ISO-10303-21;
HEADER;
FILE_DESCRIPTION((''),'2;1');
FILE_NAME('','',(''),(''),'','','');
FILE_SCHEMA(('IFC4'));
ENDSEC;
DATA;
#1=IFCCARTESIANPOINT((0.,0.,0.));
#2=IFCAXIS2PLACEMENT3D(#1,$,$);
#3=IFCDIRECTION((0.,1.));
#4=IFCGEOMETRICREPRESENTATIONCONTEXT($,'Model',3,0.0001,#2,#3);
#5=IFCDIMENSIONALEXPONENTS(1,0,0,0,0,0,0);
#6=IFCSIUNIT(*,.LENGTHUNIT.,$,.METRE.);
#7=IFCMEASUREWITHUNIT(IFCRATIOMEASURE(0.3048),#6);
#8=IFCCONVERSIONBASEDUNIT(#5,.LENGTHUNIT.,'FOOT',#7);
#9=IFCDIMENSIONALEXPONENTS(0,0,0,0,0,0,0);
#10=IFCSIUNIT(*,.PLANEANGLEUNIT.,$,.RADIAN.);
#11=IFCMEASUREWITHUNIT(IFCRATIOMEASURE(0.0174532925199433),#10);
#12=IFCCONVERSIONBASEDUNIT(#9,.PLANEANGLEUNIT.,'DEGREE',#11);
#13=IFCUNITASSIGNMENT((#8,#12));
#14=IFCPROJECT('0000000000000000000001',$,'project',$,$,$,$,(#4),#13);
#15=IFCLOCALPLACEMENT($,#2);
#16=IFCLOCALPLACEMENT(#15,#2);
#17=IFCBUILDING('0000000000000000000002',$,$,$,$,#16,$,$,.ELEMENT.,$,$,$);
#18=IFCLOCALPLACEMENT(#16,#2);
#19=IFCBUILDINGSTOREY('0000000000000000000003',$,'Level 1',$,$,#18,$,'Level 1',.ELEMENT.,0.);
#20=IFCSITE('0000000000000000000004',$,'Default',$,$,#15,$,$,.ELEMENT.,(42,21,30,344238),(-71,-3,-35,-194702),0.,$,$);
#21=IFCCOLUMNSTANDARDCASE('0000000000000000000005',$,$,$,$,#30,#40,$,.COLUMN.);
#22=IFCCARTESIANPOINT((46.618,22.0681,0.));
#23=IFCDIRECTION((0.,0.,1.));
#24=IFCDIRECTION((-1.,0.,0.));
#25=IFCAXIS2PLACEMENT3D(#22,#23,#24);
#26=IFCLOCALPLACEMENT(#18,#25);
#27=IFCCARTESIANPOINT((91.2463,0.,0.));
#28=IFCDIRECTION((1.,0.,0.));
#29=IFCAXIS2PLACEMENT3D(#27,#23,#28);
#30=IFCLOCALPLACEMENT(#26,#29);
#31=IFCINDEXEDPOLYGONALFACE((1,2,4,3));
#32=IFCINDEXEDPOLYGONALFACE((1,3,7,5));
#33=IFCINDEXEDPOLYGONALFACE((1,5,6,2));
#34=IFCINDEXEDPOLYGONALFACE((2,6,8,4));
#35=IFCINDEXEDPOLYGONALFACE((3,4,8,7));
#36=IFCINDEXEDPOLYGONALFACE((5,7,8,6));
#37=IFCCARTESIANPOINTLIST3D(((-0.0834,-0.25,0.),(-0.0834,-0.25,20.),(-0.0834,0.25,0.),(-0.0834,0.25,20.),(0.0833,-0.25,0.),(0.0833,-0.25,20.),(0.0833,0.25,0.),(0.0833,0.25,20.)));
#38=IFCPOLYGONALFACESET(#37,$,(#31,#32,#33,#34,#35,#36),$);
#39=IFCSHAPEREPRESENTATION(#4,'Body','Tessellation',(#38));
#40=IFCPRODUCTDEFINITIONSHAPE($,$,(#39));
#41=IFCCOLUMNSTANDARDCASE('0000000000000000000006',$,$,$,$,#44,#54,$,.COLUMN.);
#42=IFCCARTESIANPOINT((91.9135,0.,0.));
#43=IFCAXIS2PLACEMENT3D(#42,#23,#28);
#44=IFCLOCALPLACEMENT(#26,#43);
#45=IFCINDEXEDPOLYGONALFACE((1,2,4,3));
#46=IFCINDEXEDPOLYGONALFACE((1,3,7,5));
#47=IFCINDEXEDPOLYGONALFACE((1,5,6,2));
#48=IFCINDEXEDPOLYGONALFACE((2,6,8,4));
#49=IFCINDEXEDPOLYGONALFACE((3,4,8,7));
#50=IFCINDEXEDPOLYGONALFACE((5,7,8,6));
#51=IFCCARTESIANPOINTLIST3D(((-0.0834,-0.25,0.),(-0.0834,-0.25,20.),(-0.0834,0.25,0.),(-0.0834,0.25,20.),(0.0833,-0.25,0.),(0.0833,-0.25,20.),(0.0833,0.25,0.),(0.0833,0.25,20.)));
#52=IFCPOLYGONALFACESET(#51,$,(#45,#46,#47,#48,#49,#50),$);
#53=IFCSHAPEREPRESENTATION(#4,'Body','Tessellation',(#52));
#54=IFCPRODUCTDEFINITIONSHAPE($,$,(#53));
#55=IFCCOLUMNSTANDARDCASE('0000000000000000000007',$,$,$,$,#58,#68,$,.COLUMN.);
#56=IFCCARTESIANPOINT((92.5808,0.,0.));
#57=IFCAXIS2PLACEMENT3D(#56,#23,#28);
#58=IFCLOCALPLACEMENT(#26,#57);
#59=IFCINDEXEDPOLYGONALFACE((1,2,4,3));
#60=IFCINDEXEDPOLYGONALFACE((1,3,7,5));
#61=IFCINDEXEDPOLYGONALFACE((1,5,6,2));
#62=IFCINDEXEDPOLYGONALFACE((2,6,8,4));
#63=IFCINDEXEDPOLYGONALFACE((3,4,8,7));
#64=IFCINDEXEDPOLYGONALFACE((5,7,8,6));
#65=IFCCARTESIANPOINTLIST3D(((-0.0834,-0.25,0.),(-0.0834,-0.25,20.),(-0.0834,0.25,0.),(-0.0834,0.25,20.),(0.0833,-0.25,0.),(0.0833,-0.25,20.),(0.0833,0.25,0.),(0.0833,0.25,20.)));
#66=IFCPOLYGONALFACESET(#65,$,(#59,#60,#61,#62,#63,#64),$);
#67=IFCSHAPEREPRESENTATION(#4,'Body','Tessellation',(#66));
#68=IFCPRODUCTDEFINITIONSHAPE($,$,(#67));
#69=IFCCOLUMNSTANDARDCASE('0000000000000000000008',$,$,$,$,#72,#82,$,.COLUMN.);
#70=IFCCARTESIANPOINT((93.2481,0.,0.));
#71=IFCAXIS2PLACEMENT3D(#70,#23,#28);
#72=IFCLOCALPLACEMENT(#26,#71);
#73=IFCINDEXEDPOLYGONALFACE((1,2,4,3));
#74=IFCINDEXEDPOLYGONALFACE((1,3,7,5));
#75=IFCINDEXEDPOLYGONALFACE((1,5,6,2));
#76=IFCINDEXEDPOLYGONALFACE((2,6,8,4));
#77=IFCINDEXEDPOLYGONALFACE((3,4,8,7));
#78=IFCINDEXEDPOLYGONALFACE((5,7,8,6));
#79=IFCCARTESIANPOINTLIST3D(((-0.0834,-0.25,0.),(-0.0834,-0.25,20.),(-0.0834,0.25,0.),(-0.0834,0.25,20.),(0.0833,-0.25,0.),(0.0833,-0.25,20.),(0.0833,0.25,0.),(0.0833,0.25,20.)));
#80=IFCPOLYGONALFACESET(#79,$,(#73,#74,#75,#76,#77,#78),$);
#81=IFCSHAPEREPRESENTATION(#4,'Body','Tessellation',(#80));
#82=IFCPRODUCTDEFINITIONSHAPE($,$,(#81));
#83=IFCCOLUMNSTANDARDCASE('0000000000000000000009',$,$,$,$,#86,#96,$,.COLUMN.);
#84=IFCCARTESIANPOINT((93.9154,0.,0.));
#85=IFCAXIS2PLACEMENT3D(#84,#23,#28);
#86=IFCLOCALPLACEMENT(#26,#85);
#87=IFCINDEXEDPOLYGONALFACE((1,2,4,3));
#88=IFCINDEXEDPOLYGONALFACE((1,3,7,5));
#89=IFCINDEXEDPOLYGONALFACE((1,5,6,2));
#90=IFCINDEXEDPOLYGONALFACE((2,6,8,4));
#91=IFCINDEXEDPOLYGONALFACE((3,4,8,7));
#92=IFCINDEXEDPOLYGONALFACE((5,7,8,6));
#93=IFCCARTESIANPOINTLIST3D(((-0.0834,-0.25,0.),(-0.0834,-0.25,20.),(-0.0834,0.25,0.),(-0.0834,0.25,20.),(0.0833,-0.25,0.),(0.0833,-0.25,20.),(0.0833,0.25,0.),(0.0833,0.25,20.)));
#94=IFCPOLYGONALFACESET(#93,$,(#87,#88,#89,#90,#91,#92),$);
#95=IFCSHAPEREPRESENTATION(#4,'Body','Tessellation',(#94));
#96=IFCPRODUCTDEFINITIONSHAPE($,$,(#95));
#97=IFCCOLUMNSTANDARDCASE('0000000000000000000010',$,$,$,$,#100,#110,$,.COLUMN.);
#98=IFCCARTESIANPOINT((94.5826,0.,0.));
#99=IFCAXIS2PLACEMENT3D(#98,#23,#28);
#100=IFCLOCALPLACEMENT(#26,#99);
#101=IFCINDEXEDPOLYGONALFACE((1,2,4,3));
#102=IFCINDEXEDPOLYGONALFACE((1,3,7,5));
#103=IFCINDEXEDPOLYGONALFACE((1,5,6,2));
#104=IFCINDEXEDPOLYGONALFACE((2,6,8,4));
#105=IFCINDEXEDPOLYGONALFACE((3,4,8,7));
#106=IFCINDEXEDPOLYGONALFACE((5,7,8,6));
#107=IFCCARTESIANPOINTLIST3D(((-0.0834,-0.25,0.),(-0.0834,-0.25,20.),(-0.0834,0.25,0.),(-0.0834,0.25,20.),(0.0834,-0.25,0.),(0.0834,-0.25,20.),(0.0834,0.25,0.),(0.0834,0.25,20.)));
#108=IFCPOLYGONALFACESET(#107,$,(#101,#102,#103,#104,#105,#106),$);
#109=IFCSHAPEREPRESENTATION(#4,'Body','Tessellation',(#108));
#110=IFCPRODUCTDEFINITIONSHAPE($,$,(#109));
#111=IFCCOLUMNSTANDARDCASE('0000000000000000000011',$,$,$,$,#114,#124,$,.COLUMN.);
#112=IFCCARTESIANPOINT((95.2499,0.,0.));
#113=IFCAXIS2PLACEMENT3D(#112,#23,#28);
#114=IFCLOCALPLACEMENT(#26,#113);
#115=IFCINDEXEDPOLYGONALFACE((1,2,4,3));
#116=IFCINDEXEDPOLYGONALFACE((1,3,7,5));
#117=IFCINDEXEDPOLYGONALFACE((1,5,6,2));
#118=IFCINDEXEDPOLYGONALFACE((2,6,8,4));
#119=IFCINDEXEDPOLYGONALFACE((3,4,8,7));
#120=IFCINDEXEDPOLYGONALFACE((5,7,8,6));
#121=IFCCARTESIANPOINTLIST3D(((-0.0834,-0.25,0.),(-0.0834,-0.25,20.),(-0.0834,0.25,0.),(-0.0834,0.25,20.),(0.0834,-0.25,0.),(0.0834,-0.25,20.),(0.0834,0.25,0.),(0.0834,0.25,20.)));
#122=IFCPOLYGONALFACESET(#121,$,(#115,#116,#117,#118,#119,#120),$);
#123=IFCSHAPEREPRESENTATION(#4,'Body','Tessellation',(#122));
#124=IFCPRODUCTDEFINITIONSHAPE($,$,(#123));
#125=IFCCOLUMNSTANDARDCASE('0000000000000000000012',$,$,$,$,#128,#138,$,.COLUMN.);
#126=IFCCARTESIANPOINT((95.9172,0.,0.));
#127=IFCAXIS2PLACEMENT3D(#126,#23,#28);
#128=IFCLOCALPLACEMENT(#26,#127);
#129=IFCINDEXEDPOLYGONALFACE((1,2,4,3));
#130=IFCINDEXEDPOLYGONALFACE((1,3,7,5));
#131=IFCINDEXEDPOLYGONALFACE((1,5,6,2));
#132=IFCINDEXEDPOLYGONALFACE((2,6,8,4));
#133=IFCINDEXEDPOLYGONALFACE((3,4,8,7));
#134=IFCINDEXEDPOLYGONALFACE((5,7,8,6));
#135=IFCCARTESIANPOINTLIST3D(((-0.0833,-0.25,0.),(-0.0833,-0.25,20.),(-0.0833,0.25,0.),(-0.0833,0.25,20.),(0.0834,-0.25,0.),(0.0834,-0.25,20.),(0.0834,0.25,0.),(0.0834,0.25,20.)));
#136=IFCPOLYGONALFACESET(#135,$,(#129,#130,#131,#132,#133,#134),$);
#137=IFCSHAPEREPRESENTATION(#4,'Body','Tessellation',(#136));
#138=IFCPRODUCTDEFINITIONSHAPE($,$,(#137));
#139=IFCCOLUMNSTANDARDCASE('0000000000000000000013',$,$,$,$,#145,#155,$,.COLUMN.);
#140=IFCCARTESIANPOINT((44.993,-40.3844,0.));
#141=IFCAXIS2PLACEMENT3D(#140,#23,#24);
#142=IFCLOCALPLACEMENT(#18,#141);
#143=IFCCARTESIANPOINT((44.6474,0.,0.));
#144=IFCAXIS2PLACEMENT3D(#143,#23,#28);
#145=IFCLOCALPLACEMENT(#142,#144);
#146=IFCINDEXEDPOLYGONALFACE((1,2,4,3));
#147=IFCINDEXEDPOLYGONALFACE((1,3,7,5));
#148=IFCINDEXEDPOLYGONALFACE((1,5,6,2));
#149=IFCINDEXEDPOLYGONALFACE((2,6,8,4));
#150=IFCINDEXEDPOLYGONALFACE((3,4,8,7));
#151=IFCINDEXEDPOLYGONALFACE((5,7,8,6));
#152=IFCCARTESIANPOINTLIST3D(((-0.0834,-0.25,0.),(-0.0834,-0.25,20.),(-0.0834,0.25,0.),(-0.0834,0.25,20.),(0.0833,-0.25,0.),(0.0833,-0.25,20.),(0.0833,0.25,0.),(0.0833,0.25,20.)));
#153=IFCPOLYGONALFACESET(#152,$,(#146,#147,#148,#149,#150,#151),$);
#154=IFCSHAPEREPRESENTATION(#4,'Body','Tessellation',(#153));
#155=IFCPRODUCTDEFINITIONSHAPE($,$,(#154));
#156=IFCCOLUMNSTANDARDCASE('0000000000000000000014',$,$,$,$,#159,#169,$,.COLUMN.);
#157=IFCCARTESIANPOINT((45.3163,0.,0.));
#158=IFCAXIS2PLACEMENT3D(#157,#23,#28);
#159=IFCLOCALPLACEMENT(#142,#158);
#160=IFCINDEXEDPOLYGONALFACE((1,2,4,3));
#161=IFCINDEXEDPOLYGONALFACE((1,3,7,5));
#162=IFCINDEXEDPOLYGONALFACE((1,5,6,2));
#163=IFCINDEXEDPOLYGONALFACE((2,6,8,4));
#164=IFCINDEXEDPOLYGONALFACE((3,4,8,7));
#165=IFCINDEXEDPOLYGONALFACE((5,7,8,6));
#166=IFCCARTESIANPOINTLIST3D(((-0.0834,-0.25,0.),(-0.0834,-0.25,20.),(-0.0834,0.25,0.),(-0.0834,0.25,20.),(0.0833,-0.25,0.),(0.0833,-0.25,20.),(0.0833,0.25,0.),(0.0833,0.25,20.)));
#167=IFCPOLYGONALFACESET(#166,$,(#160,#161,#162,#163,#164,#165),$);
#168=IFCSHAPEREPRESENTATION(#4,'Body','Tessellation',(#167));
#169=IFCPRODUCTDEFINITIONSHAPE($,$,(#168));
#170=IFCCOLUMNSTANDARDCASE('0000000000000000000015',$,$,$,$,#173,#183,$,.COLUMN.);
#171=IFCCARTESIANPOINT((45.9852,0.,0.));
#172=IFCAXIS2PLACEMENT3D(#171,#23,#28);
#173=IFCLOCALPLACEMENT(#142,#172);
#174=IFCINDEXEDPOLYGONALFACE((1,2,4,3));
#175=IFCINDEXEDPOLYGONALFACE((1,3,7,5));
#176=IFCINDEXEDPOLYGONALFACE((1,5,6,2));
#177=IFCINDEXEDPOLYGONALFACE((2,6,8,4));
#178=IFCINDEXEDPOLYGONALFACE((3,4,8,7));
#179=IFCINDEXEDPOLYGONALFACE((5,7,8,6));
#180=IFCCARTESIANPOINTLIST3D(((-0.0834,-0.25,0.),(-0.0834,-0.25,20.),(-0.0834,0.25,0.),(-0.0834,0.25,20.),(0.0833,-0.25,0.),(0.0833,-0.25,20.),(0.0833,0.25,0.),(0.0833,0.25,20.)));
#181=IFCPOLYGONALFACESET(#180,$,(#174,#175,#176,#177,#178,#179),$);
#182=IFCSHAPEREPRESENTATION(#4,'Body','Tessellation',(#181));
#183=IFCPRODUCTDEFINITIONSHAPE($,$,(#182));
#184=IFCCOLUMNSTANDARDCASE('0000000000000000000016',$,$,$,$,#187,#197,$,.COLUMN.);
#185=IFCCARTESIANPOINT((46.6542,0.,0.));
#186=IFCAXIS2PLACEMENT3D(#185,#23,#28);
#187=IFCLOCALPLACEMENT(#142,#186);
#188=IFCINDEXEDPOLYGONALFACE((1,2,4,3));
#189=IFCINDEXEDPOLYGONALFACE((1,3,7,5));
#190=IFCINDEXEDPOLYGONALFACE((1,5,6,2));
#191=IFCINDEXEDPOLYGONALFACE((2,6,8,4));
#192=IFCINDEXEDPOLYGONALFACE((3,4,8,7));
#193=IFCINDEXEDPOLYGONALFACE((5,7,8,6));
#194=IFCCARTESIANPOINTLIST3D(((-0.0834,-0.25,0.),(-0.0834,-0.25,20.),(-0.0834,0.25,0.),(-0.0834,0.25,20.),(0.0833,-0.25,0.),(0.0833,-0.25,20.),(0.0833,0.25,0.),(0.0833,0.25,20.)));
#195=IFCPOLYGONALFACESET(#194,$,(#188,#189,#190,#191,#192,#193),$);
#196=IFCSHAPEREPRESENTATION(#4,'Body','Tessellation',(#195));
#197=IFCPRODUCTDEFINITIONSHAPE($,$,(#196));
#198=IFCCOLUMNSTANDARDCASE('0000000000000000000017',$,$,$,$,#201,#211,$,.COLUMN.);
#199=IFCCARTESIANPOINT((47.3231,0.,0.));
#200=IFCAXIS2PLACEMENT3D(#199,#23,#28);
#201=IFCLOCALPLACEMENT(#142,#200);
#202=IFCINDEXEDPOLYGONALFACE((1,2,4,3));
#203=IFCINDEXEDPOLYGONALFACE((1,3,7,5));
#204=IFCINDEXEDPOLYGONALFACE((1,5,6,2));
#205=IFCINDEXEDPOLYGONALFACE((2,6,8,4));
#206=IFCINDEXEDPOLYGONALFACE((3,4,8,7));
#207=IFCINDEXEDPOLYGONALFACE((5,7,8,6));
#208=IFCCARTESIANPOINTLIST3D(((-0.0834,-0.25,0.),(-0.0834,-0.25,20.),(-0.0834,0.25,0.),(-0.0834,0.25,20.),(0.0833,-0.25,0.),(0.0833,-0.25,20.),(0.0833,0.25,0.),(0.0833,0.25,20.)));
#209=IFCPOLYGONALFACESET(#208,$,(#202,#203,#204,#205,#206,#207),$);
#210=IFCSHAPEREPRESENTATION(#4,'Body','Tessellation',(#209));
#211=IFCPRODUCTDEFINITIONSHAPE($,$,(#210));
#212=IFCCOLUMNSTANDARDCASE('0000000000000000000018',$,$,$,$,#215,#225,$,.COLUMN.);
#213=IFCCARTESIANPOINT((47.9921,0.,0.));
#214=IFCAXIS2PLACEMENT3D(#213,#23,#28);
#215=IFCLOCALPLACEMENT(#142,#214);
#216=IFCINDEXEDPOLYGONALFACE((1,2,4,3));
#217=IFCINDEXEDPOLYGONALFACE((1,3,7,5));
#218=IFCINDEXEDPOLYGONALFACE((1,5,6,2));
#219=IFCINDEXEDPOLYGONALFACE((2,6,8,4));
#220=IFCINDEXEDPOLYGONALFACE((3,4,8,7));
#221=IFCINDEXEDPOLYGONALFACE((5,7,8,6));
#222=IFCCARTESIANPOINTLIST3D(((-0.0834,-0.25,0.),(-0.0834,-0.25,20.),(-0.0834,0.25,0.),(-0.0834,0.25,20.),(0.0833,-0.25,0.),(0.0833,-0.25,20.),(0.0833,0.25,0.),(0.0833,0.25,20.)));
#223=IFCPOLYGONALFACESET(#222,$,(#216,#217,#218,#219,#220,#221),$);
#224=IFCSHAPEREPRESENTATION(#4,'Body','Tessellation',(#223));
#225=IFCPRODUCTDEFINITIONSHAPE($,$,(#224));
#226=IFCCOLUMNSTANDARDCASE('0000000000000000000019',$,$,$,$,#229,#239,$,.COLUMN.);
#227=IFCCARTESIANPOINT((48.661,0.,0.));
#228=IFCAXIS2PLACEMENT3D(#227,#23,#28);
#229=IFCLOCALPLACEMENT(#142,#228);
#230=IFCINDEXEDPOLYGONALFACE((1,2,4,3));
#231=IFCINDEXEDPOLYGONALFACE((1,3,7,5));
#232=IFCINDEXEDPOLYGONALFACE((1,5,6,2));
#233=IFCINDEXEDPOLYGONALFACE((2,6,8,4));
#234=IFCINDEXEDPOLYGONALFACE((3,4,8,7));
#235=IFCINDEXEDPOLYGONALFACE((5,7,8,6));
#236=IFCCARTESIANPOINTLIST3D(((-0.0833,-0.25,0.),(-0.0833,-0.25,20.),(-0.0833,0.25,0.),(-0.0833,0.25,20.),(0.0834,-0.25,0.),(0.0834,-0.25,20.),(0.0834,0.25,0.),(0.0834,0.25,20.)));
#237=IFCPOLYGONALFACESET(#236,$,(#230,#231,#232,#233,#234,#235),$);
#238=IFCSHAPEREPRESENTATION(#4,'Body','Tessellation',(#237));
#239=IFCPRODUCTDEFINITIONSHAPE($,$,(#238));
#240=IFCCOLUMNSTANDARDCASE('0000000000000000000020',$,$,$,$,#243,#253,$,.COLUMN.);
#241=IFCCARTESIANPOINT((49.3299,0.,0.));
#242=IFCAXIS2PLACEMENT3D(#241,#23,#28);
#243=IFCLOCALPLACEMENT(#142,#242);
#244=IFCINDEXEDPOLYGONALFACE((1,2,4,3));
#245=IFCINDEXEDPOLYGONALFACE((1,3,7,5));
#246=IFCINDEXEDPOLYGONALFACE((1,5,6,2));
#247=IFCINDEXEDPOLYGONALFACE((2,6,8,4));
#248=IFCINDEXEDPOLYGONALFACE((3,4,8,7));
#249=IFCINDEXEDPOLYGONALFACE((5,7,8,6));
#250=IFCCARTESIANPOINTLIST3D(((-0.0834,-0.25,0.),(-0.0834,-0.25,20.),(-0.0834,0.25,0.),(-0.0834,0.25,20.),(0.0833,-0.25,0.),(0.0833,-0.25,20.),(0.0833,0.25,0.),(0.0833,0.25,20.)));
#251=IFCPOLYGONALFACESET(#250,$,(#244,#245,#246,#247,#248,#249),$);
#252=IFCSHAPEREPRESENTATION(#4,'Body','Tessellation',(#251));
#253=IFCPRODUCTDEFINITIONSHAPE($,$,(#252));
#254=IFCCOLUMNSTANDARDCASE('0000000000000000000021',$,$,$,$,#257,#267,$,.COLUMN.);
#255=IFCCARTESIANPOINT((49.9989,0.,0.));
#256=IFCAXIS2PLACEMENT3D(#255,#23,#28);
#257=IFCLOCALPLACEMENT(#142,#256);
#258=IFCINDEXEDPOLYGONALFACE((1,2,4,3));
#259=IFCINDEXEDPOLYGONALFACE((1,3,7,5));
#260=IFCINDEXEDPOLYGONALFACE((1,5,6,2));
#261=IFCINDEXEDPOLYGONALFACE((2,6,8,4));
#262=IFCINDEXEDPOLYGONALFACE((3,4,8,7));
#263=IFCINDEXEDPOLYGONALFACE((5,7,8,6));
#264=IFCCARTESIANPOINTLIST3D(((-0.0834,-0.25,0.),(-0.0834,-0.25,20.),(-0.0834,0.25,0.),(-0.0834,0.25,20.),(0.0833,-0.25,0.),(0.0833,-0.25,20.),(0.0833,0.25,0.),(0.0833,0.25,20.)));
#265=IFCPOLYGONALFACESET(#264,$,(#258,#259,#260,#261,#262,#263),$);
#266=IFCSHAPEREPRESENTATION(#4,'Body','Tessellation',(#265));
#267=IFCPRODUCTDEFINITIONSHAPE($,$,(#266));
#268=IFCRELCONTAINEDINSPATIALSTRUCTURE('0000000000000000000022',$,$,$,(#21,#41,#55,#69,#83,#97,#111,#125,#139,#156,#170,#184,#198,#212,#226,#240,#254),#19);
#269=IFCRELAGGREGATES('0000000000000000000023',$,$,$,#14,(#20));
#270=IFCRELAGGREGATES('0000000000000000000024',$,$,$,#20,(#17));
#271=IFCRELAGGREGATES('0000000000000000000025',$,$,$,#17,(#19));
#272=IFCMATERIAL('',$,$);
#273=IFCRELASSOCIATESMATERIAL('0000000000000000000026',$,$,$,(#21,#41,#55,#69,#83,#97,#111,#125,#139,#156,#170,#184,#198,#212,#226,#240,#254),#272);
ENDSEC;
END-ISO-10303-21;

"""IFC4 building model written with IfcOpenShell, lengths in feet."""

from ifc_helpers import new_model, entity, si_unit, converted_unit, direction, frame, origin, place, context, project, spatial, rectangle, extrude, material, element, save


model = new_model("IFC4")

# Units and contexts
model_context = context("Model", 3, precision=0.0001, world=origin(), true_north=direction((0.0, 1.0)))
ifc_project = project(units=[converted_unit("LENGTHUNIT", "FOOT", entity("IfcRatioMeasure", 0.3048), si_unit("LENGTHUNIT", "METRE"), dimensions=[1, 0, 0, 0, 0, 0, 0]), converted_unit("PLANEANGLEUNIT", "DEGREE", entity("IfcRatioMeasure", 0.0174532925199433), si_unit("PLANEANGLEUNIT", "RADIAN"), dimensions=[0, 0, 0, 0, 0, 0, 0])], contexts=[model_context])

# Site, building, storey
site_placement = place(None, origin())
site = spatial("IfcSite", under=ifc_project, at=site_placement, Name="Default", CompositionType="ELEMENT", RefLatitude=(42, 21, 30, 344238), RefLongitude=(-71, -3, -35, -194702), RefElevation=0.0)
building_placement = place(site_placement, origin())
building = spatial("IfcBuilding", under=site, at=building_placement, CompositionType="ELEMENT")
storey_placement = place(building_placement, origin())
storey = spatial("IfcBuildingStorey", under=building, at=storey_placement, Name="Level 1", LongName="Level 1", CompositionType="ELEMENT", Elevation=0.0)

# Columns
ifc_material = material(Name="")
placement_1 = place(storey_placement, frame((46.618, 22.0681, 0.0), z_axis=(0.0, 0.0, 1.0), x_axis=(-1.0, 0.0, 0.0)))
for number, where, z_axis, x_axis in (
    (1, (91.2463, 0.0, 0.0), (0.0, 0.0, 1.0), (1.0, 0.0, 0.0)),
    (2, (91.9135, 0.0, 0.0), (0.0, 0.0, 1.0), (1.0, 0.0, 0.0)),
    (3, (92.5808, 0.0, 0.0), (0.0, 0.0, 1.0), (1.0, 0.0, 0.0)),
    (4, (93.2481, 0.0, 0.0), (0.0, 0.0, 1.0), (1.0, 0.0, 0.0)),
    (5, (93.9154, 0.0, 0.0), (0.0, 0.0, 1.0), (1.0, 0.0, 0.0)),
    (6, (94.5826, 0.0, 0.0), (0.0, 0.0, 1.0), (1.0, 0.0, 0.0)),
    (7, (95.2499, 0.0, 0.0), (0.0, 0.0, 1.0), (1.0, 0.0, 0.0)),
    (8, (95.9172, 0.0, 0.0), (0.0, 0.0, 1.0), (1.0, 0.0, 0.0)),
):
    element("IfcColumnStandardCase", number, at=place(placement_1, frame(where, z_axis=z_axis, x_axis=x_axis)), inside=storey, material=ifc_material, PredefinedType="COLUMN", context=model_context, shape_type="SweptSolid", body=[
        extrude(rectangle(XDim=0.1667, YDim=0.5), origin(), (0.0, 0.0, 1.0), 20.0),
    ])
placement_2 = place(storey_placement, frame((44.993, -40.3844, 0.0), z_axis=(0.0, 0.0, 1.0), x_axis=(-1.0, 0.0, 0.0)))
for number, where, z_axis, x_axis in (
    (9, (44.6474, 0.0, 0.0), (0.0, 0.0, 1.0), (1.0, 0.0, 0.0)),
    (10, (45.3163, 0.0, 0.0), (0.0, 0.0, 1.0), (1.0, 0.0, 0.0)),
    (11, (45.9852, 0.0, 0.0), (0.0, 0.0, 1.0), (1.0, 0.0, 0.0)),
    (12, (46.6542, 0.0, 0.0), (0.0, 0.0, 1.0), (1.0, 0.0, 0.0)),
    (13, (47.3231, 0.0, 0.0), (0.0, 0.0, 1.0), (1.0, 0.0, 0.0)),
    (14, (47.9921, 0.0, 0.0), (0.0, 0.0, 1.0), (1.0, 0.0, 0.0)),
    (15, (48.661, 0.0, 0.0), (0.0, 0.0, 1.0), (1.0, 0.0, 0.0)),
    (16, (49.3299, 0.0, 0.0), (0.0, 0.0, 1.0), (1.0, 0.0, 0.0)),
    (17, (49.9989, 0.0, 0.0), (0.0, 0.0, 1.0), (1.0, 0.0, 0.0)),
):
    element("IfcColumnStandardCase", number, at=place(placement_2, frame(where, z_axis=z_axis, x_axis=x_axis)), inside=storey, material=ifc_material, PredefinedType="COLUMN", context=model_context, shape_type="SweptSolid", body=[
        extrude(rectangle(XDim=0.1667, YDim=0.5), origin(), (0.0, 0.0, 1.0), 20.0),
    ])

save(model, "model.ifc")
